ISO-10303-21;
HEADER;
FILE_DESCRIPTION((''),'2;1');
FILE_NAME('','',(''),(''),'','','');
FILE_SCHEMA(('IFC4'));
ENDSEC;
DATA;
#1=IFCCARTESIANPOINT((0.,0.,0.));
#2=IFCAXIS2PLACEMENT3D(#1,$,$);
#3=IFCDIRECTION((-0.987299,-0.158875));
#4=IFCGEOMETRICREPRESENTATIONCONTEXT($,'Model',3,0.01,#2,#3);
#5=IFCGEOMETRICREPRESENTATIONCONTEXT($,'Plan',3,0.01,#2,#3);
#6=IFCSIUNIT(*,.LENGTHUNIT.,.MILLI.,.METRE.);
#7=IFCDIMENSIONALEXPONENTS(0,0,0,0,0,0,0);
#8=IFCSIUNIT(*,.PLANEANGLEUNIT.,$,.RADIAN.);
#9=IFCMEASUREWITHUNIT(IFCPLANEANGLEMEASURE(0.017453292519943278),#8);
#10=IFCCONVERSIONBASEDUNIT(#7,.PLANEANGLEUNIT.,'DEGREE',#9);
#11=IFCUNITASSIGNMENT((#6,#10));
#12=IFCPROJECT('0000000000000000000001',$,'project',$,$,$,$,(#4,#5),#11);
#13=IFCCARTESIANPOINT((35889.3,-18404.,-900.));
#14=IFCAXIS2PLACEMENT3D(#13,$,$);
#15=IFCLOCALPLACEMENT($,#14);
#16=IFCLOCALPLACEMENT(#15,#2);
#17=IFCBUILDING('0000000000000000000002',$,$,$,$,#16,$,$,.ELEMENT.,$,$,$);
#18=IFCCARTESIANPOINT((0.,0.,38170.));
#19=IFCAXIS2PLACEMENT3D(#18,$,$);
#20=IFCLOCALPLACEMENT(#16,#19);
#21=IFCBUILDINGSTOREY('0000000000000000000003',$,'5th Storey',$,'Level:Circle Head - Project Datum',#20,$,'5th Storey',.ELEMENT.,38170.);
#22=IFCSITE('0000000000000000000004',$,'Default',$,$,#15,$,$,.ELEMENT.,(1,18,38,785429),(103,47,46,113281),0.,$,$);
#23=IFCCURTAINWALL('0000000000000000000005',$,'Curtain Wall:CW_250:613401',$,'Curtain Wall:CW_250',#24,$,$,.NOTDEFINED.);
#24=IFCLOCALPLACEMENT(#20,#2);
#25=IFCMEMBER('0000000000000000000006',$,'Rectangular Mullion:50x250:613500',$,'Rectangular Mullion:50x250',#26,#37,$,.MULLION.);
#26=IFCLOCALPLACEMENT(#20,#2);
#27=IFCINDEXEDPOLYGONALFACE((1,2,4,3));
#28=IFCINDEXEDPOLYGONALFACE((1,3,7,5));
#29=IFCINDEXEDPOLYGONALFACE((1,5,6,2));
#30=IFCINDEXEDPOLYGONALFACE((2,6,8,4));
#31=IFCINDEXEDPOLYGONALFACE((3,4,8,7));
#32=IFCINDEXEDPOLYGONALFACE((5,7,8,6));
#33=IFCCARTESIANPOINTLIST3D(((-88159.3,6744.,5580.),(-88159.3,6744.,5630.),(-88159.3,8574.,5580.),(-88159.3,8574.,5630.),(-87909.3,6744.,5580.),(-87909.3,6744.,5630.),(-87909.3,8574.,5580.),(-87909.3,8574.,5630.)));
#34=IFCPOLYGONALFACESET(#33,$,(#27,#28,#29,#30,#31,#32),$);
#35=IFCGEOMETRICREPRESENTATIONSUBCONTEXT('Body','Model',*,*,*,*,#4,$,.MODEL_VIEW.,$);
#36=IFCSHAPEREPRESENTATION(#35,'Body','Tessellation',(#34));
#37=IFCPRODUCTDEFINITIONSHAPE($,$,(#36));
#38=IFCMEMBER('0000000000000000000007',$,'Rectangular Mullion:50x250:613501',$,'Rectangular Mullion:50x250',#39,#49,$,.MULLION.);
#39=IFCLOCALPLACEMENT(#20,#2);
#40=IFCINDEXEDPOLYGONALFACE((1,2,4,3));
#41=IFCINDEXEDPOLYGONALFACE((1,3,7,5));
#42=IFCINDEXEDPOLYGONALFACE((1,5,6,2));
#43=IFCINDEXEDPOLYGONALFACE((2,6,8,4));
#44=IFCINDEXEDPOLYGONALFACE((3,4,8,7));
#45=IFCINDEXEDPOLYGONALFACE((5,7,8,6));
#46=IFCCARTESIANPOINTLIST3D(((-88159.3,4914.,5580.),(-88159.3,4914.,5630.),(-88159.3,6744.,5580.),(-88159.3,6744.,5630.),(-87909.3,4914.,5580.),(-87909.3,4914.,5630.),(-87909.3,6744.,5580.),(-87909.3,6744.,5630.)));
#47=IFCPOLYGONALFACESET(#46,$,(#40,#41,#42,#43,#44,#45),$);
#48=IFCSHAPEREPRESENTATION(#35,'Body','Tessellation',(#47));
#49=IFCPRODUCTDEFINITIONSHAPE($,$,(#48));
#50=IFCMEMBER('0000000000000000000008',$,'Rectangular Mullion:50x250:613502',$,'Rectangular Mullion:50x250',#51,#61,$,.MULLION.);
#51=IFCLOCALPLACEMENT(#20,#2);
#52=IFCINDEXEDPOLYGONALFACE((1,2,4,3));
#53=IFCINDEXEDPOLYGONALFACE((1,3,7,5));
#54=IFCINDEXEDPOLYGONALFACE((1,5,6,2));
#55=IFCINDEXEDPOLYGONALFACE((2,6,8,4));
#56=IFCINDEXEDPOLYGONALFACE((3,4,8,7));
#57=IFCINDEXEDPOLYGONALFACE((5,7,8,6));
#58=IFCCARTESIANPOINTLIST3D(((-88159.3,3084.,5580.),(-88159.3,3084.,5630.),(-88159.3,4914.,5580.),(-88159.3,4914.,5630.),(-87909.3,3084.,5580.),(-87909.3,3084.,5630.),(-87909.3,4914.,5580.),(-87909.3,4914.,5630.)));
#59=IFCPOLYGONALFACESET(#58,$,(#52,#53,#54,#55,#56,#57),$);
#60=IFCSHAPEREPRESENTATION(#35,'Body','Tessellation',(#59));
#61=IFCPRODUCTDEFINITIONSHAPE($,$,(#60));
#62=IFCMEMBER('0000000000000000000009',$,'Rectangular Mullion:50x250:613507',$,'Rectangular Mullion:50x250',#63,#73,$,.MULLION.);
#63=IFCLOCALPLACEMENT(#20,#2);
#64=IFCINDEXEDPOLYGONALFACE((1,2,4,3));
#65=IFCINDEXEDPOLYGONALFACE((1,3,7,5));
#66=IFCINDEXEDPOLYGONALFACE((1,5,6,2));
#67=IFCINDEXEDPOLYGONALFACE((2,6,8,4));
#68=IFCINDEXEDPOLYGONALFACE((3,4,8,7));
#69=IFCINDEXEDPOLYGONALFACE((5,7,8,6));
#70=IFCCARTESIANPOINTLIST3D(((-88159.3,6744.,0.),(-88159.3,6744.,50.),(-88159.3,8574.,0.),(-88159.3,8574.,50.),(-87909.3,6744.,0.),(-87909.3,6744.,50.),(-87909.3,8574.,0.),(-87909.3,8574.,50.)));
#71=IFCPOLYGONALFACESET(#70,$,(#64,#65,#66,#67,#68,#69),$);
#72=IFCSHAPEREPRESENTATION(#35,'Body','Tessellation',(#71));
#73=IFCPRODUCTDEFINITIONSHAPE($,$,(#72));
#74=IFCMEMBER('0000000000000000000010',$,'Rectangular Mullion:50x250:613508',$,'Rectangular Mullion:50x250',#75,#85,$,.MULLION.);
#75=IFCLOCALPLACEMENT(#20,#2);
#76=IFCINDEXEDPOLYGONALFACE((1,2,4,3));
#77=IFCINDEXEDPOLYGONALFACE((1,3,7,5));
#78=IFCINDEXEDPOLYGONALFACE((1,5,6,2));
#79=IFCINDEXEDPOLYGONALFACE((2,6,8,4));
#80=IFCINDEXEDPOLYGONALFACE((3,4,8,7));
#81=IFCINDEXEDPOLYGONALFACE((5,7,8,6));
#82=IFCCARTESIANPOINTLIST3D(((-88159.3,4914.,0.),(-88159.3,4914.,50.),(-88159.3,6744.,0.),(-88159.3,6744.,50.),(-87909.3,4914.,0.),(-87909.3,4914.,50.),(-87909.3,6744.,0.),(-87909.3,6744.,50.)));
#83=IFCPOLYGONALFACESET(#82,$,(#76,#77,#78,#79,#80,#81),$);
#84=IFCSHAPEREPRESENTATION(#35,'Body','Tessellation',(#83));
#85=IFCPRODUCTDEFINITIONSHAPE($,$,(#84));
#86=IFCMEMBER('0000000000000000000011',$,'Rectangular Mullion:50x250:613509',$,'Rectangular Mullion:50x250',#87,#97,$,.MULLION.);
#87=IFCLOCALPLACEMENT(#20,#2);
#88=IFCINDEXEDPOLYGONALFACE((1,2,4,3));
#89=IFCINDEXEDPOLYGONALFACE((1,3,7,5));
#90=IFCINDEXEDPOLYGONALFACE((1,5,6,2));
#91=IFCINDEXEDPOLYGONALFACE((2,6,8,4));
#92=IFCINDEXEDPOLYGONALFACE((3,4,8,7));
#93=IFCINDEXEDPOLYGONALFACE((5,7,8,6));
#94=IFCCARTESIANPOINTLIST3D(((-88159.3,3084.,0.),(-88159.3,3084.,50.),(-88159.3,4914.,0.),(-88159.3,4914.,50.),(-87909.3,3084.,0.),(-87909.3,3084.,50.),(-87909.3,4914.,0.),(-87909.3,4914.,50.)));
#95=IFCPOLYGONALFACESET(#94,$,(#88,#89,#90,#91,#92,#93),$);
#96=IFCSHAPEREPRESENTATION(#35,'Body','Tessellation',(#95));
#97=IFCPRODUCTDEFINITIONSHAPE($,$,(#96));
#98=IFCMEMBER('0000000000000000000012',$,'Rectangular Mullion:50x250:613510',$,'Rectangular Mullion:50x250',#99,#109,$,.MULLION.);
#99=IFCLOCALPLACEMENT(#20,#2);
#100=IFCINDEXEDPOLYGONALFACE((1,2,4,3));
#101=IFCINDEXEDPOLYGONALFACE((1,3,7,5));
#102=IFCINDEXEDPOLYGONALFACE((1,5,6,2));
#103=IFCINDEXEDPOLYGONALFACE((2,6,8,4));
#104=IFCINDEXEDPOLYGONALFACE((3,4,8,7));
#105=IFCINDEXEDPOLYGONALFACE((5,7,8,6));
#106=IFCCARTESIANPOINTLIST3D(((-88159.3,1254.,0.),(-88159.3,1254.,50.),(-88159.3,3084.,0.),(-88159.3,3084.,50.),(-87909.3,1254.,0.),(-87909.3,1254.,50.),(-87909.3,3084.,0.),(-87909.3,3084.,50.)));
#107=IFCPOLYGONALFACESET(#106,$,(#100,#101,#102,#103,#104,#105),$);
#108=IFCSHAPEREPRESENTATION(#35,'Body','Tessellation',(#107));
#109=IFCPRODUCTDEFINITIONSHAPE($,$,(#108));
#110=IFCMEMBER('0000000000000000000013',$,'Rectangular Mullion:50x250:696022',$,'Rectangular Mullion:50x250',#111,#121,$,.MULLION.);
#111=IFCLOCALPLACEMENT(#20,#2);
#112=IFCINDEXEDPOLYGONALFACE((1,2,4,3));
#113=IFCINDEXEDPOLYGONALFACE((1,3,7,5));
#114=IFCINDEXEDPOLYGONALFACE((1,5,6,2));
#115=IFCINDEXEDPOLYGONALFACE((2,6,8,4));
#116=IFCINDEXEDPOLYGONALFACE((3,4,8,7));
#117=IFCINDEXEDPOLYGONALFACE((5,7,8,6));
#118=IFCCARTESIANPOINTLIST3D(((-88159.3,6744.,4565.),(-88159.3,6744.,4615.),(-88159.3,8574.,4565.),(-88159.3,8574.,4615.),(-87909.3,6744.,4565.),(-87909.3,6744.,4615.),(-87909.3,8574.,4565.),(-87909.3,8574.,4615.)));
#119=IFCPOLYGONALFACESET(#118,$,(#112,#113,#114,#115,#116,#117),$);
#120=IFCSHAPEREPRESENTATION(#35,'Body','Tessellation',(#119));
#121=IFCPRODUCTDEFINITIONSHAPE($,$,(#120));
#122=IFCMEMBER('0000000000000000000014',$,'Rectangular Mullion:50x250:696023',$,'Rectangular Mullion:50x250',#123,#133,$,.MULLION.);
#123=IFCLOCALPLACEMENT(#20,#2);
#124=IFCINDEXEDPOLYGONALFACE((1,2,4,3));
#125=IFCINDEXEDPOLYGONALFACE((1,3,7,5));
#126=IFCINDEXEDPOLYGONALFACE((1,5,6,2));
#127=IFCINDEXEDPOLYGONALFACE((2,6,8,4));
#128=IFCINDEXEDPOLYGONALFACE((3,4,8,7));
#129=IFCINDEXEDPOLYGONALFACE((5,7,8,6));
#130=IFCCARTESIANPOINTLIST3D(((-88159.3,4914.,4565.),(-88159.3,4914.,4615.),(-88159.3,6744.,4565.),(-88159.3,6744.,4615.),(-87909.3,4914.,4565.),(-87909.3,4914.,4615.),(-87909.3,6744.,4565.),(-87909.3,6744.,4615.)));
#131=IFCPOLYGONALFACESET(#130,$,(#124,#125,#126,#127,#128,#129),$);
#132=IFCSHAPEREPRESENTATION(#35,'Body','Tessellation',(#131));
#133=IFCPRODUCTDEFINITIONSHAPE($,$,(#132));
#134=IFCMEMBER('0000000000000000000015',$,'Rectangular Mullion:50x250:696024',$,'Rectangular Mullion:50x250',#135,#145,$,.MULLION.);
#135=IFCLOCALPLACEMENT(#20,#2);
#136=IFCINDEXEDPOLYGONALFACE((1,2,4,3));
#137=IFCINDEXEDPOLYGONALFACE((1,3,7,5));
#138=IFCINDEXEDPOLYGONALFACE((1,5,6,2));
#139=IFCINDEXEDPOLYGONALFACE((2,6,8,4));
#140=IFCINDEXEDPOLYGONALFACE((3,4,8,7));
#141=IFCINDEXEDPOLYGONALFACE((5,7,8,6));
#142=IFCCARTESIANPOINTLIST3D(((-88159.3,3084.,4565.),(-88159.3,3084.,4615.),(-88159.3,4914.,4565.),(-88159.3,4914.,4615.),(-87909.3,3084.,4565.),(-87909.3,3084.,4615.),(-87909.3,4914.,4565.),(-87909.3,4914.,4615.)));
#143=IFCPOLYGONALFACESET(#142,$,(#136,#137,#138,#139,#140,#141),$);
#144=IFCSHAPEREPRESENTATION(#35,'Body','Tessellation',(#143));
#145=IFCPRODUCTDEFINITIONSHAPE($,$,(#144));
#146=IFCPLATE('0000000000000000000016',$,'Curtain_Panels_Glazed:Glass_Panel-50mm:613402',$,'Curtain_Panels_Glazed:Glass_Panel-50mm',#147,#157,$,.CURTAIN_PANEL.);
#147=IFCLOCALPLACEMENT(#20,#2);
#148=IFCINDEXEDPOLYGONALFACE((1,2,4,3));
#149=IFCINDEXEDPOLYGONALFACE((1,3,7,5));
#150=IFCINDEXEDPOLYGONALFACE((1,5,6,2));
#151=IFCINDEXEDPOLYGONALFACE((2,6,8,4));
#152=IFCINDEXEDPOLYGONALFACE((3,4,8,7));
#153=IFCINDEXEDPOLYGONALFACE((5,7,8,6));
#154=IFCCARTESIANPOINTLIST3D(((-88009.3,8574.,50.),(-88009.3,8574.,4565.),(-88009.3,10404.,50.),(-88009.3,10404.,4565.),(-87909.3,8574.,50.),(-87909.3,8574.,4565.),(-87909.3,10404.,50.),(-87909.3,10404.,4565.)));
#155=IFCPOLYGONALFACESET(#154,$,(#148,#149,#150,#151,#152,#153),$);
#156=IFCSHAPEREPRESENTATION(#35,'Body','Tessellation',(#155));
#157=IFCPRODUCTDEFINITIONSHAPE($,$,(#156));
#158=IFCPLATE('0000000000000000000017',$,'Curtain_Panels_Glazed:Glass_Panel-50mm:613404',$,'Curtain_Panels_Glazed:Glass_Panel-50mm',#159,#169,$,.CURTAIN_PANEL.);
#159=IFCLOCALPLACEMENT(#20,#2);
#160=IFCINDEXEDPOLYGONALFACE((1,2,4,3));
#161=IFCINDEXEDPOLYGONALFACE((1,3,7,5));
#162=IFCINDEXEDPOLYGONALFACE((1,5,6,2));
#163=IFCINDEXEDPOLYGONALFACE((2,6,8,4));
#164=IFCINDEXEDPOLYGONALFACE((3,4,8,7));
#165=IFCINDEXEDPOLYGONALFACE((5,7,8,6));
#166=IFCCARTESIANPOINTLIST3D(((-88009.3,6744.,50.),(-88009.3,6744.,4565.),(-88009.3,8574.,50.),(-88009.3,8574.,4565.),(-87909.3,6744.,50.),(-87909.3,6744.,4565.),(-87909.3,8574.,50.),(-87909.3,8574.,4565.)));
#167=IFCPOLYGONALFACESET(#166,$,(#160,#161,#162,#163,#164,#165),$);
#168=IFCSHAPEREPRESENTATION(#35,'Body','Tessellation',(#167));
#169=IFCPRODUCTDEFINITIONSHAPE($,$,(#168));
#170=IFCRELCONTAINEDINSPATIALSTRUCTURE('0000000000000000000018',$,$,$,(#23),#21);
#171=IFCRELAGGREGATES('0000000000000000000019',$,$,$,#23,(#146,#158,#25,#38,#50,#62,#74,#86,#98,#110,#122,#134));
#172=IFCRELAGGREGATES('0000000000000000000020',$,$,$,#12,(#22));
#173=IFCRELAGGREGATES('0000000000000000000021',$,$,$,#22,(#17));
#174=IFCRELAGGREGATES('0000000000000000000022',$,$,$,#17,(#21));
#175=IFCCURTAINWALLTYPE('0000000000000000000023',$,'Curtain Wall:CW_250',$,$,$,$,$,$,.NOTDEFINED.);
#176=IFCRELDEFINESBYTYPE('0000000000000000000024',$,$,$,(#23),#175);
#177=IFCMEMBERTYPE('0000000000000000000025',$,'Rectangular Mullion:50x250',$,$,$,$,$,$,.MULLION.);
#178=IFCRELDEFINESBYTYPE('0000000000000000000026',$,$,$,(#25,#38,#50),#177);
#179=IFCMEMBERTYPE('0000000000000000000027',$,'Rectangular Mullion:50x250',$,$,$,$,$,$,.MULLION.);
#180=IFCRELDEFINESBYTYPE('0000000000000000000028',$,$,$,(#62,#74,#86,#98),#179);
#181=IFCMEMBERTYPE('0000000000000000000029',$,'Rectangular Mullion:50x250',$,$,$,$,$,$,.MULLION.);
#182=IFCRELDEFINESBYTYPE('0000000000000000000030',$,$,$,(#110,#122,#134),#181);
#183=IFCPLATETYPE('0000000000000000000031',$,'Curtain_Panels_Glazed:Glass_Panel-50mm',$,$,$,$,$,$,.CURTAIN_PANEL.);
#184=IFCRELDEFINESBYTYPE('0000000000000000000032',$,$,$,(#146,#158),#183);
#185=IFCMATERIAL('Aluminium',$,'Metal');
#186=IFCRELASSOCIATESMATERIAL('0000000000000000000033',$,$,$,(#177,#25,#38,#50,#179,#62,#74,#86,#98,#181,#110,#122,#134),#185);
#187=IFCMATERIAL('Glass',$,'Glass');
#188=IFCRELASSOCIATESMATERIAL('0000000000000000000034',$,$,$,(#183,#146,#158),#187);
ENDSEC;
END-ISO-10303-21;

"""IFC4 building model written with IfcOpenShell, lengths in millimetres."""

from ifc_helpers import new_model, entity, si_unit, converted_unit, direction, frame, origin, place, context, subcontext, project, spatial, indexed_curve, outline, extrude, source, transform, mapped, material, type_object, type_shapes, element, aggregate, save


model = new_model("IFC4")

# Units and contexts
model_context = context("Model", 3, precision=0.01, world=origin(), true_north=direction((-0.987299, -0.158875)))
plan_context = context("Plan", 3, precision=0.01, world=origin(), true_north=direction((-0.987299, -0.158875)))
body_context = subcontext(model_context, "Body", "Model", "MODEL_VIEW")
ifc_project = project(units=[si_unit("LENGTHUNIT", "METRE", prefix="MILLI"), converted_unit("PLANEANGLEUNIT", "DEGREE", entity("IfcPlaneAngleMeasure", 0.017453292519943278), si_unit("PLANEANGLEUNIT", "RADIAN"), dimensions=[0, 0, 0, 0, 0, 0, 0])], contexts=[model_context, plan_context])

# Site, building, storey
site_placement = place(None, frame((35889.3, -18404.0, -900.0)))
site = spatial("IfcSite", under=ifc_project, at=site_placement, Name="Default", CompositionType="ELEMENT", RefLatitude=(1, 18, 38, 785429), RefLongitude=(103, 47, 46, 113281), RefElevation=0.0)
building_placement = place(site_placement, origin())
building = spatial("IfcBuilding", under=site, at=building_placement, CompositionType="ELEMENT")
storey_placement = place(building_placement, frame((0.0, 0.0, 38170.0)))
storey = spatial("IfcBuildingStorey", under=building, at=storey_placement, Name="5th Storey", ObjectType="Level:Circle Head - Project Datum", LongName="5th Storey", CompositionType="ELEMENT", Elevation=38170.0)

# Curtain wall, members
curtain_wall_type = type_object("IfcCurtainWallType", Name="Curtain Wall:CW_250", PredefinedType="NOTDEFINED")
curtain_wall_1_placement = place(storey_placement, frame((0.0, 0.0, -38170.0)))
curtain_wall_1 = element("IfcCurtainWall", 1, at=curtain_wall_1_placement, inside=storey, type_object=curtain_wall_type, Name="Curtain Wall:CW_250:613401", ObjectType="Curtain Wall:CW_250", PredefinedType="NOTDEFINED")
ifc_material_1 = material(Name="Aluminium", Category="Metal")
member_type_1 = type_object("IfcMemberType", Name="Rectangular Mullion:50x250", PredefinedType="MULLION", material=ifc_material_1)
shared_shape_1 = source(origin(), body_context, "Body", "SweptSolid", [
    extrude(outline(indexed_curve([(-25.0, -125.0), (25.0, -125.0), (25.0, 125.0), (-25.0, 125.0), (-25.0, -125.0)], self_intersect=False)), frame((-25.0, -125.0, -1830.0), z_axis=(0.0, 0.0, 1.0), x_axis=(-1.0, 0.0, 0.0)), (0.0, 0.0, 1.0), 1830.0),
])
type_shapes(member_type_1, [shared_shape_1])
member_1_placement = place(curtain_wall_1_placement, frame((-88159.3, 6744.0, 43800.0), z_axis=(0.0, -1.0, 0.0), x_axis=(0.0, 0.0, 1.0)))
member_1 = element("IfcMember", 2, at=member_1_placement, type_object=member_type_1, material=ifc_material_1, Name="Rectangular Mullion:50x250:613500", ObjectType="Rectangular Mullion:50x250", PredefinedType="MULLION", context=body_context, shape_type="MappedRepresentation", body=[
    mapped(shared_shape_1, transform((0.0, 0.0, 0.0), scale=1.0)),
])
member_2_placement = place(curtain_wall_1_placement, frame((-88159.3, 4914.0, 43800.0), z_axis=(0.0, -1.0, 0.0), x_axis=(0.0, 0.0, 1.0)))
member_2 = element("IfcMember", 3, at=member_2_placement, type_object=member_type_1, material=ifc_material_1, Name="Rectangular Mullion:50x250:613501", ObjectType="Rectangular Mullion:50x250", PredefinedType="MULLION", context=body_context, shape_type="MappedRepresentation", body=[
    mapped(shared_shape_1, transform((0.0, 0.0, 0.0), scale=1.0)),
])
member_3_placement = place(curtain_wall_1_placement, frame((-88159.3, 3084.0, 43800.0), z_axis=(0.0, -1.0, 0.0), x_axis=(0.0, 0.0, 1.0)))
member_3 = element("IfcMember", 4, at=member_3_placement, type_object=member_type_1, material=ifc_material_1, Name="Rectangular Mullion:50x250:613502", ObjectType="Rectangular Mullion:50x250", PredefinedType="MULLION", context=body_context, shape_type="MappedRepresentation", body=[
    mapped(shared_shape_1, transform((0.0, 0.0, 0.0), scale=1.0)),
])
member_type_2 = type_object("IfcMemberType", Name="Rectangular Mullion:50x250", PredefinedType="MULLION", material=ifc_material_1)
shared_shape_2 = source(origin(), body_context, "Body", "SweptSolid", [
    extrude(outline(indexed_curve([(-25.0, -125.0), (25.0, -125.0), (25.0, 125.0), (-25.0, 125.0), (-25.0, -125.0)], self_intersect=False)), frame((-25.0, -125.0, -1830.0), z_axis=(0.0, 0.0, 1.0), x_axis=(-1.0, 0.0, 0.0)), (0.0, 0.0, 1.0), 1830.0),
])
type_shapes(member_type_2, [shared_shape_2])
member_4_placement = place(curtain_wall_1_placement, frame((-88159.3, 8574.0, 38170.0), z_axis=(0.0, 1.0, 0.0), x_axis=(0.0, 0.0, -1.0)))
member_4 = element("IfcMember", 5, at=member_4_placement, type_object=member_type_2, material=ifc_material_1, Name="Rectangular Mullion:50x250:613507", ObjectType="Rectangular Mullion:50x250", PredefinedType="MULLION", context=body_context, shape_type="MappedRepresentation", body=[
    mapped(shared_shape_2, transform((0.0, 0.0, 0.0), scale=1.0)),
])
member_5_placement = place(curtain_wall_1_placement, frame((-88159.3, 6744.0, 38170.0), z_axis=(0.0, 1.0, 0.0), x_axis=(0.0, 0.0, -1.0)))
member_5 = element("IfcMember", 6, at=member_5_placement, type_object=member_type_2, material=ifc_material_1, Name="Rectangular Mullion:50x250:613508", ObjectType="Rectangular Mullion:50x250", PredefinedType="MULLION", context=body_context, shape_type="MappedRepresentation", body=[
    mapped(shared_shape_2, transform((0.0, 0.0, 0.0), scale=1.0)),
])
member_6_placement = place(curtain_wall_1_placement, frame((-88159.3, 4914.0, 38170.0), z_axis=(0.0, 1.0, 0.0), x_axis=(0.0, 0.0, -1.0)))
member_6 = element("IfcMember", 7, at=member_6_placement, type_object=member_type_2, material=ifc_material_1, Name="Rectangular Mullion:50x250:613509", ObjectType="Rectangular Mullion:50x250", PredefinedType="MULLION", context=body_context, shape_type="MappedRepresentation", body=[
    mapped(shared_shape_2, transform((0.0, 0.0, 0.0), scale=1.0)),
])
member_7_placement = place(curtain_wall_1_placement, frame((-88159.3, 3084.0, 38170.0), z_axis=(0.0, 1.0, 0.0), x_axis=(0.0, 0.0, -1.0)))
member_7 = element("IfcMember", 8, at=member_7_placement, type_object=member_type_2, material=ifc_material_1, Name="Rectangular Mullion:50x250:613510", ObjectType="Rectangular Mullion:50x250", PredefinedType="MULLION", context=body_context, shape_type="MappedRepresentation", body=[
    mapped(shared_shape_2, transform((0.0, 0.0, 0.0), scale=1.0)),
])

# Members
member_type_3 = type_object("IfcMemberType", Name="Rectangular Mullion:50x250", PredefinedType="MULLION", material=ifc_material_1)
shared_shape_3 = source(origin(), body_context, "Body", "SweptSolid", [
    extrude(outline(indexed_curve([(-25.0, -125.0), (25.0, -125.0), (25.0, 125.0), (-25.0, 125.0), (-25.0, -125.0)], self_intersect=False)), frame((0.0, -125.0, -1830.0), z_axis=(0.0, 0.0, 1.0), x_axis=(-1.0, 0.0, 0.0)), (0.0, 0.0, 1.0), 1830.0),
])
type_shapes(member_type_3, [shared_shape_3])
member_8_placement = place(curtain_wall_1_placement, frame((-88159.3, 6744.0, 42760.0), z_axis=(0.0, -1.0, 0.0), x_axis=(0.0, 0.0, 1.0)))
member_8 = element("IfcMember", 9, at=member_8_placement, type_object=member_type_3, material=ifc_material_1, Name="Rectangular Mullion:50x250:696022", ObjectType="Rectangular Mullion:50x250", PredefinedType="MULLION", context=body_context, shape_type="MappedRepresentation", body=[
    mapped(shared_shape_3, transform((0.0, 0.0, 0.0), scale=1.0)),
])
member_9_placement = place(curtain_wall_1_placement, frame((-88159.3, 4914.0, 42760.0), z_axis=(0.0, -1.0, 0.0), x_axis=(0.0, 0.0, 1.0)))
member_9 = element("IfcMember", 10, at=member_9_placement, type_object=member_type_3, material=ifc_material_1, Name="Rectangular Mullion:50x250:696023", ObjectType="Rectangular Mullion:50x250", PredefinedType="MULLION", context=body_context, shape_type="MappedRepresentation", body=[
    mapped(shared_shape_3, transform((0.0, 0.0, 0.0), scale=1.0)),
])
member_10_placement = place(curtain_wall_1_placement, frame((-88159.3, 3084.0, 42760.0), z_axis=(0.0, -1.0, 0.0), x_axis=(0.0, 0.0, 1.0)))
member_10 = element("IfcMember", 11, at=member_10_placement, type_object=member_type_3, material=ifc_material_1, Name="Rectangular Mullion:50x250:696024", ObjectType="Rectangular Mullion:50x250", PredefinedType="MULLION", context=body_context, shape_type="MappedRepresentation", body=[
    mapped(shared_shape_3, transform((0.0, 0.0, 0.0), scale=1.0)),
])

# Plates
ifc_material_2 = material(Name="Glass", Category="Glass")
plate_type_1 = type_object("IfcPlateType", Name="Curtain_Panels_Glazed:Glass_Panel-50mm", PredefinedType="CURTAIN_PANEL", material=ifc_material_2)
shared_shape_4 = source(origin(), body_context, "Body", "SweptSolid", [
    extrude(outline(indexed_curve([(-50.0, -915.0), (50.0, -915.0), (50.0, 915.0), (-50.0, 915.0), (-50.0, -915.0)], self_intersect=False)), frame((0.0, 200.0, 0.0), z_axis=(0.0, 0.0, 1.0), x_axis=(0.0, 1.0, 0.0)), (0.0, 0.0, 1.0), 4515.0),
])
type_shapes(plate_type_1, [shared_shape_4])
plate_1_placement = place(curtain_wall_1_placement, frame((-88159.3, 9489.0, 38220.0), z_axis=(0.0, 0.0, 1.0), x_axis=(0.0, -1.0, 0.0)))
plate_1 = element("IfcPlate", 12, at=plate_1_placement, type_object=plate_type_1, material=ifc_material_2, Name="Curtain_Panels_Glazed:Glass_Panel-50mm:613402", ObjectType="Curtain_Panels_Glazed:Glass_Panel-50mm", PredefinedType="CURTAIN_PANEL", context=body_context, shape_type="MappedRepresentation", body=[
    mapped(shared_shape_4, transform((0.0, 0.0, 0.0), scale=1.0)),
])
plate_2_placement = place(curtain_wall_1_placement, frame((-88159.3, 7659.0, 38220.0), z_axis=(0.0, 0.0, 1.0), x_axis=(0.0, -1.0, 0.0)))
plate_2 = element("IfcPlate", 13, at=plate_2_placement, type_object=plate_type_1, material=ifc_material_2, Name="Curtain_Panels_Glazed:Glass_Panel-50mm:613404", ObjectType="Curtain_Panels_Glazed:Glass_Panel-50mm", PredefinedType="CURTAIN_PANEL", context=body_context, shape_type="MappedRepresentation", body=[
    mapped(shared_shape_4, transform((0.0, 0.0, 0.0), scale=1.0)),
])
aggregate(curtain_wall_1, [plate_1, plate_2, member_1, member_2, member_3, member_4, member_5, member_6, member_7, member_8, member_9, member_10])

save(model, "model.ifc")
